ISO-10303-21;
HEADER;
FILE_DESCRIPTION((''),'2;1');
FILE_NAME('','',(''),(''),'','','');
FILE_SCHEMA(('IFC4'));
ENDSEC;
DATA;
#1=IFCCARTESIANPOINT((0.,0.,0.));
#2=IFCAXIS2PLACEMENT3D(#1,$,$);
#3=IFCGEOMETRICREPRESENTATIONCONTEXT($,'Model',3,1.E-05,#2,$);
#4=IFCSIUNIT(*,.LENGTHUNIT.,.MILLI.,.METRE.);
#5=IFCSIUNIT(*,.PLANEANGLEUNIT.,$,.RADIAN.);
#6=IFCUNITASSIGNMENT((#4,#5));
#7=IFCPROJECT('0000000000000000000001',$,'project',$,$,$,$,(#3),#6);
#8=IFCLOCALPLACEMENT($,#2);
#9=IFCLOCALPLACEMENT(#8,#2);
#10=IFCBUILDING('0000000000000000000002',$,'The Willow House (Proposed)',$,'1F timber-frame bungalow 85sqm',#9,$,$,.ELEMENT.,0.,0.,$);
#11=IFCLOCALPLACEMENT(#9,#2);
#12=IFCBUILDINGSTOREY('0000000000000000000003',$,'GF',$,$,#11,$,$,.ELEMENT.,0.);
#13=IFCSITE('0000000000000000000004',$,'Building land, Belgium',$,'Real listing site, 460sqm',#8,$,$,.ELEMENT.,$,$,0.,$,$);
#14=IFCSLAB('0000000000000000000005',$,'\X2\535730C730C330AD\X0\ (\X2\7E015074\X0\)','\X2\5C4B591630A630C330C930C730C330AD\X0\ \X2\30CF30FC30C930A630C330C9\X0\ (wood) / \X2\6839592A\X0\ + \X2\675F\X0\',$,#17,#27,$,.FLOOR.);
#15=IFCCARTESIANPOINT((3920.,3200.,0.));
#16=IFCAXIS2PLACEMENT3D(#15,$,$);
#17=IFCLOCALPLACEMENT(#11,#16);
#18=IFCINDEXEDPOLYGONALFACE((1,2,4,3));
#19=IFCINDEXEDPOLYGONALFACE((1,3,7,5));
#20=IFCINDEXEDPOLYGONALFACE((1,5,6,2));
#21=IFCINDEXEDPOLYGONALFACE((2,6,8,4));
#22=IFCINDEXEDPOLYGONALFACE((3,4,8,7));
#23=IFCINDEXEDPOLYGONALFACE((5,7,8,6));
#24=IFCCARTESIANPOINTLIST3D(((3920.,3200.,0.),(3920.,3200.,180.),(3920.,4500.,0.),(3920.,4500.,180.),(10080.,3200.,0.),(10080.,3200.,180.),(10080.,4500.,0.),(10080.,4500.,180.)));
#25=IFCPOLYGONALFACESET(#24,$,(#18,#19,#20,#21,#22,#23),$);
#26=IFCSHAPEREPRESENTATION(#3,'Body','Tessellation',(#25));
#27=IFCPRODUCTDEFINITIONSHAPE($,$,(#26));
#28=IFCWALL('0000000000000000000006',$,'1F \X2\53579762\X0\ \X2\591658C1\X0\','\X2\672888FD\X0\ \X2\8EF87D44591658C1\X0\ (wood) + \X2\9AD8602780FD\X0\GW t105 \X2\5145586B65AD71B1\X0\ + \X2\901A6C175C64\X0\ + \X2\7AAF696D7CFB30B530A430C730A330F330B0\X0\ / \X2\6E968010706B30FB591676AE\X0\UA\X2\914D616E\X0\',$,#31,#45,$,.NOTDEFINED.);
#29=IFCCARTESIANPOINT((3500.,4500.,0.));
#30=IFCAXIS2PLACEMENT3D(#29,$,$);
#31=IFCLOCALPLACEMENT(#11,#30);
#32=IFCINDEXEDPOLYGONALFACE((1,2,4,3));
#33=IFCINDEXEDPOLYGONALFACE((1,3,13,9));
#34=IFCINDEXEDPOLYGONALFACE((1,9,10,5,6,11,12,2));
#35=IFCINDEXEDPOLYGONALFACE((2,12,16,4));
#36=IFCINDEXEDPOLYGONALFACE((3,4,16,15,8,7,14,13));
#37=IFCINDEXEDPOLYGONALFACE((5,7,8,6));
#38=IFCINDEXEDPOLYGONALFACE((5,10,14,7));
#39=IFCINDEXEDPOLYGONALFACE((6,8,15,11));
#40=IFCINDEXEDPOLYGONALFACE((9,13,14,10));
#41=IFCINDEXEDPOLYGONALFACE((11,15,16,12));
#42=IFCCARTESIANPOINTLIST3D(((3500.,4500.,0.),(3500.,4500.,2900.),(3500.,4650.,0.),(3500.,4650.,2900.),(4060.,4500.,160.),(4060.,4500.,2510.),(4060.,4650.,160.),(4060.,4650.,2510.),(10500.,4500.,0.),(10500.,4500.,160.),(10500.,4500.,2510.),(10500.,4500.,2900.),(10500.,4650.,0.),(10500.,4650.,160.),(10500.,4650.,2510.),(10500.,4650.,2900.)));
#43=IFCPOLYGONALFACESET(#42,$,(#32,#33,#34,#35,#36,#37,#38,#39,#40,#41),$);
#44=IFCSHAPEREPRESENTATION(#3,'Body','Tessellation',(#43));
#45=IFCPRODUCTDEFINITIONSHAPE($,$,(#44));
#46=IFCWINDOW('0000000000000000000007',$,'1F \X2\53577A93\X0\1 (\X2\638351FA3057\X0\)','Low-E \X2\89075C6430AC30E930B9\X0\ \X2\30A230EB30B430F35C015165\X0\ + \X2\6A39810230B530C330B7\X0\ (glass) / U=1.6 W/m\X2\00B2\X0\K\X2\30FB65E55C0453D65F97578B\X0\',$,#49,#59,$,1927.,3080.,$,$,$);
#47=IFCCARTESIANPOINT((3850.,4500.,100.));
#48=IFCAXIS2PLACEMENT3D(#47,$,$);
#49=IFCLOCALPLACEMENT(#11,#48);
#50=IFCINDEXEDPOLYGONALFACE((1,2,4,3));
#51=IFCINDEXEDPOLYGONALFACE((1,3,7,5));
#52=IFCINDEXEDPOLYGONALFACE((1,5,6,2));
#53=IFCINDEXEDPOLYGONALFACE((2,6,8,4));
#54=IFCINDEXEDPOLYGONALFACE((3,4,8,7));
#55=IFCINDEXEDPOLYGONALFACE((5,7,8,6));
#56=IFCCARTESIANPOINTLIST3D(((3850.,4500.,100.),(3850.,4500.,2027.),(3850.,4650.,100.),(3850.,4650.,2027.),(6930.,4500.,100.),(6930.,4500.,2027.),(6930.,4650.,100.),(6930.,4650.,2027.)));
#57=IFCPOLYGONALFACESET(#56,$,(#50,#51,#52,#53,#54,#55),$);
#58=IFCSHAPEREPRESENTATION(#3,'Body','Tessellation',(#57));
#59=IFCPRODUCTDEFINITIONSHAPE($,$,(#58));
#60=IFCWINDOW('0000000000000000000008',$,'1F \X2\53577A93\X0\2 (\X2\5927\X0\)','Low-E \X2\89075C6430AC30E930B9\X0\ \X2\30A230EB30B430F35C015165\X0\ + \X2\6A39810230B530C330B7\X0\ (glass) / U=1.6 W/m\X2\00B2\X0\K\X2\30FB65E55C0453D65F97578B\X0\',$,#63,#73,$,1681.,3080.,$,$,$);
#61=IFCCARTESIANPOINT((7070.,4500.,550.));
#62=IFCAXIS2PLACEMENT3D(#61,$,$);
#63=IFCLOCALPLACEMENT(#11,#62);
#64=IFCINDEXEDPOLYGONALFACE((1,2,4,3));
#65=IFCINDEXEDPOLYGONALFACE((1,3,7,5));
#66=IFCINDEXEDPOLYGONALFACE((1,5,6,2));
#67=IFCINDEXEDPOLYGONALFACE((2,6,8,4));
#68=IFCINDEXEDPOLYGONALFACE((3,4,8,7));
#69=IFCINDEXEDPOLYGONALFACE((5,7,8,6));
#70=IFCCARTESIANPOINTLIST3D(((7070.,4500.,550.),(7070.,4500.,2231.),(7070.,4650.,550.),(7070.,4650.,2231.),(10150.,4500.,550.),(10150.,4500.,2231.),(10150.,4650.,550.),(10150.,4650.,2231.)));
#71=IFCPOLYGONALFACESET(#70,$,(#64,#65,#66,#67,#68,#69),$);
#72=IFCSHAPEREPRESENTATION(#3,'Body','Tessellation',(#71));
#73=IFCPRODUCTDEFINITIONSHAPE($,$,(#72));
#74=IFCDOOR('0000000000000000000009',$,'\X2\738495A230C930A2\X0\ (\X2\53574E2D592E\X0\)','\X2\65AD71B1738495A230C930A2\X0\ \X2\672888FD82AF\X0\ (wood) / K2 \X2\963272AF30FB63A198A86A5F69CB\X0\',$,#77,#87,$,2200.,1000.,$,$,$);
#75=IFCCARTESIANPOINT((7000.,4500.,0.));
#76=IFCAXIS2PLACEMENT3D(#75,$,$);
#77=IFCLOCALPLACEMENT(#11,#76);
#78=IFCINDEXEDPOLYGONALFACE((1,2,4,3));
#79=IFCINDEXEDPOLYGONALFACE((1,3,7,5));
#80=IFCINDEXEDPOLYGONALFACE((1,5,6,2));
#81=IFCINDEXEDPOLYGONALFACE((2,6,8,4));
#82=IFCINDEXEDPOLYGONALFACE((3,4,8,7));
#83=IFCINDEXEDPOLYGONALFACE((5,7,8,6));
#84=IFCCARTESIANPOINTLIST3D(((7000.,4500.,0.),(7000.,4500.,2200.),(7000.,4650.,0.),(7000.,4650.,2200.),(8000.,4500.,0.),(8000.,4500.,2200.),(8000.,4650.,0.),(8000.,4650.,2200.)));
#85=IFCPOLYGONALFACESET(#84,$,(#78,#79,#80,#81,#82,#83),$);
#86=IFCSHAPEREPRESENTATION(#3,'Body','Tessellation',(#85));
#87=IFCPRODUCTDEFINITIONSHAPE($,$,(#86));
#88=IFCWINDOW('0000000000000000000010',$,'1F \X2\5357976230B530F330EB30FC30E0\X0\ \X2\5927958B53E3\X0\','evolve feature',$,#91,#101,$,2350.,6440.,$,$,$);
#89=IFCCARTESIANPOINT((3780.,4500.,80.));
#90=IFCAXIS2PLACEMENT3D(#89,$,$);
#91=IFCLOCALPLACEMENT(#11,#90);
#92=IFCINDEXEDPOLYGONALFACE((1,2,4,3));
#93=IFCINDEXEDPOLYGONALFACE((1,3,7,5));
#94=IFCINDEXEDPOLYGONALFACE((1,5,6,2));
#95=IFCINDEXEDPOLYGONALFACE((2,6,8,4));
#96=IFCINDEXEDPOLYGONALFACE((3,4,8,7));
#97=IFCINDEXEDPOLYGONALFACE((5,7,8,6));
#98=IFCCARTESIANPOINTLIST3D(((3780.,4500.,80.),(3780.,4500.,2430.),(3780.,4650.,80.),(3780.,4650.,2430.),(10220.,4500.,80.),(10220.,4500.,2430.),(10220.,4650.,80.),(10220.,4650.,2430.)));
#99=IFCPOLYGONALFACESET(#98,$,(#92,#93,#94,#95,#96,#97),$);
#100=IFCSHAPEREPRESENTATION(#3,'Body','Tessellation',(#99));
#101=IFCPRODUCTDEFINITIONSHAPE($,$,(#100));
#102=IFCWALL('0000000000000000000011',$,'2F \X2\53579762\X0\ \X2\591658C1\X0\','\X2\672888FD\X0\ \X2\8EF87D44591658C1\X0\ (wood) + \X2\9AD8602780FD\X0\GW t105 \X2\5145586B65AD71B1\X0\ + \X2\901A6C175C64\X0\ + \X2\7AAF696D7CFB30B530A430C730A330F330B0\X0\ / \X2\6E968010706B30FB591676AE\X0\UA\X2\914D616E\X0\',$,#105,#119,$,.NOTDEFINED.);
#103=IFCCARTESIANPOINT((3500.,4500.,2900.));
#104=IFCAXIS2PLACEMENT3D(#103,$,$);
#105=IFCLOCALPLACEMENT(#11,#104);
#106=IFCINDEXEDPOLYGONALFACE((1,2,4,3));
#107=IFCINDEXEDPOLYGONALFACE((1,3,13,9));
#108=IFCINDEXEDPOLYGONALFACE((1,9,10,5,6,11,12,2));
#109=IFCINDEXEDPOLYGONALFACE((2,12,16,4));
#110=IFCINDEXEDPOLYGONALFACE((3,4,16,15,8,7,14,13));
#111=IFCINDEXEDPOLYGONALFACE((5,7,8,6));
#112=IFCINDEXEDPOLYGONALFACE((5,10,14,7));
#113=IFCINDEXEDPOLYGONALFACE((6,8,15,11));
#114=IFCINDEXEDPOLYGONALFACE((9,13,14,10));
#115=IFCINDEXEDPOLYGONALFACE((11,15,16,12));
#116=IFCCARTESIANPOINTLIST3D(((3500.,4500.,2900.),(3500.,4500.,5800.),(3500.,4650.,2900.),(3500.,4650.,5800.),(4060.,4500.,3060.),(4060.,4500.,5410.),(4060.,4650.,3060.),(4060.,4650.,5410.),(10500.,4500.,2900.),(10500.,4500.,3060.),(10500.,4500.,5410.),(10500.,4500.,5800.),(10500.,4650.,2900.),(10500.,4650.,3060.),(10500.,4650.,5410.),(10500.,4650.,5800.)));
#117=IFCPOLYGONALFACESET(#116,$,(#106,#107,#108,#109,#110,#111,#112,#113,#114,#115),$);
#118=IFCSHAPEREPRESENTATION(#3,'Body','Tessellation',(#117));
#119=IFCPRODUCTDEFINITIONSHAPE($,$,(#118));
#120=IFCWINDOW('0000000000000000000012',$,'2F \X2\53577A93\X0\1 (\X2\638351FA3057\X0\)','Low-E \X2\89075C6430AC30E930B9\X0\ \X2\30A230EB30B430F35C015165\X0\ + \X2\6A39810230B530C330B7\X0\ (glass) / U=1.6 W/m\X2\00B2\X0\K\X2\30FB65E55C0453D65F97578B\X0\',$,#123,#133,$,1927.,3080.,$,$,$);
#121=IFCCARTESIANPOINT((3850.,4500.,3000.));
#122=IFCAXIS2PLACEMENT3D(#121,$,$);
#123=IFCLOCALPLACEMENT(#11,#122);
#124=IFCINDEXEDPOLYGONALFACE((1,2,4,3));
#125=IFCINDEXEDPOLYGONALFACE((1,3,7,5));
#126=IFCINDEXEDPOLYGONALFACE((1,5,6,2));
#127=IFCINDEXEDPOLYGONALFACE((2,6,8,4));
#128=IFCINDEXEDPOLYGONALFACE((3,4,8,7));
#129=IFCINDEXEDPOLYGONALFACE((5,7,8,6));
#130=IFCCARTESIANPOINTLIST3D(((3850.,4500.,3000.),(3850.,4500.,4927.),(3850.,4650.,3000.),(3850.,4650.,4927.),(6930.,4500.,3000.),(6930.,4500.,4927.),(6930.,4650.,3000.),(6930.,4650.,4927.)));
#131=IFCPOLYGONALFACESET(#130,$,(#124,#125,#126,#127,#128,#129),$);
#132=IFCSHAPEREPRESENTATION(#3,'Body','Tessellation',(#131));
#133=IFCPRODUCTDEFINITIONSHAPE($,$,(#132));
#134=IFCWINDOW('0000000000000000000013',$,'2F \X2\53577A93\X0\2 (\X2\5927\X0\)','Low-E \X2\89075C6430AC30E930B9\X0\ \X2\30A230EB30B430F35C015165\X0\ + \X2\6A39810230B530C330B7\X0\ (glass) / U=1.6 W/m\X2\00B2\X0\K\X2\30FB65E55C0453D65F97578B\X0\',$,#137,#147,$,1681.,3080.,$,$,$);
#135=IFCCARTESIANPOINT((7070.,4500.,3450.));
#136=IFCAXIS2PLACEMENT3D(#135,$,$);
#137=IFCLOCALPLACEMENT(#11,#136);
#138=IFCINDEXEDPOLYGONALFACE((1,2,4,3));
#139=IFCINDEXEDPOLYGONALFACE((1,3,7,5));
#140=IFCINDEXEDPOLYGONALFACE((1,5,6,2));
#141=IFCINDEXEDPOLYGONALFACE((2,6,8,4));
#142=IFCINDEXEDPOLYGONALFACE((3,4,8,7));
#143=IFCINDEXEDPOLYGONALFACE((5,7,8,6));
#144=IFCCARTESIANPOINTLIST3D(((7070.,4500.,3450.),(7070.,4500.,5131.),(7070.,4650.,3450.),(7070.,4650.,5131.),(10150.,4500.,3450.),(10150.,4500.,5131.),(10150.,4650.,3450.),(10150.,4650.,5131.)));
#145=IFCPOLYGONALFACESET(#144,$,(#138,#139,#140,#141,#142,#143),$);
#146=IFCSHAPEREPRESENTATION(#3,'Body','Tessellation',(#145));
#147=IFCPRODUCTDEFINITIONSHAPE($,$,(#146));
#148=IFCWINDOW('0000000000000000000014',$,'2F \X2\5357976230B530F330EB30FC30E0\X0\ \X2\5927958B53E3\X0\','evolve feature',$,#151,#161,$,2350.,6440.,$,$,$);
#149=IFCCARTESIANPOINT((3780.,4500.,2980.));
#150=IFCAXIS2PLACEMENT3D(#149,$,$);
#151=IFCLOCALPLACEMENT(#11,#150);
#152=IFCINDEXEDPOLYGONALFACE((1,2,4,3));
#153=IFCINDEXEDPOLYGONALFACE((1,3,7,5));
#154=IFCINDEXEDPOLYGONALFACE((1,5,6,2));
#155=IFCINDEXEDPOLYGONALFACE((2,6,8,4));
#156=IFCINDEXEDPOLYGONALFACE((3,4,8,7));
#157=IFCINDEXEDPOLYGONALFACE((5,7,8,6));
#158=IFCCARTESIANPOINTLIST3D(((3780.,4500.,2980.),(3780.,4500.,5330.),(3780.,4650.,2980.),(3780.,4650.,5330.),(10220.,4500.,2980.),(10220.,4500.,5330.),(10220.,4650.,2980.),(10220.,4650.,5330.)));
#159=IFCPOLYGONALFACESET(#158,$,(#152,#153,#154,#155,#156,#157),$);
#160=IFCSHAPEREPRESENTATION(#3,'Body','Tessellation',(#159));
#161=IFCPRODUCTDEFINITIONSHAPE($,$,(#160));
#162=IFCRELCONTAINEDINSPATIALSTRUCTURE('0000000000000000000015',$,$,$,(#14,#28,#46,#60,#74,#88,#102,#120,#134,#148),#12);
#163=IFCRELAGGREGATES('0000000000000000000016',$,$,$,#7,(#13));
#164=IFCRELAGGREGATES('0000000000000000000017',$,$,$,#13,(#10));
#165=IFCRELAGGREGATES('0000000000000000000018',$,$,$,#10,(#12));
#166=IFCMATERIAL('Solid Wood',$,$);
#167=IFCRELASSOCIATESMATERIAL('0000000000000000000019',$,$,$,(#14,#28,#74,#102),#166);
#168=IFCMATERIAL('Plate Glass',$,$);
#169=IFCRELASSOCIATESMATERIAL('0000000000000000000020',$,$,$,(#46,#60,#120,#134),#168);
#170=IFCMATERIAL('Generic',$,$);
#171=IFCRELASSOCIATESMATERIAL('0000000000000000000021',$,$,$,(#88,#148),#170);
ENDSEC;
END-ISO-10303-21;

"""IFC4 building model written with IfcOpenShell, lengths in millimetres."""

from ifc_helpers import new_model, si_unit, frame, frame_2d, origin, place, context, project, spatial, rectangle, extrude, material, element, fill, save


model = new_model("IFC4")

# Units and contexts
model_context = context("Model", 3, precision=1e-05, world=origin())
ifc_project = project(units=[si_unit("LENGTHUNIT", "METRE", prefix="MILLI"), si_unit("PLANEANGLEUNIT", "RADIAN")], contexts=[model_context])

# Site, building, storey
site_placement = place(None, origin())
site = spatial("IfcSite", under=ifc_project, at=site_placement, Name="Building land, Belgium", ObjectType="Real listing site, 460sqm", CompositionType="ELEMENT", RefElevation=0.0)
building_placement = place(site_placement, origin())
building = spatial("IfcBuilding", under=site, at=building_placement, Name="The Willow House (Proposed)", ObjectType="1F timber-frame bungalow 85sqm", CompositionType="ELEMENT", ElevationOfRefHeight=0.0, ElevationOfTerrain=0.0)
storey_placement = place(building_placement, origin())
storey = spatial("IfcBuildingStorey", under=building, at=storey_placement, Name="GF", CompositionType="ELEMENT", Elevation=0.0)

# Slab
ifc_material_1 = material(Name="Solid Wood")
slab_1_placement = place(storey_placement, frame((3920.0, 3200.0, 0.0)))
element("IfcSlab", 1, at=slab_1_placement, inside=storey, material=ifc_material_1, Name="南デッキ (縁側)", Description="屋外ウッドデッキ ハードウッド (wood) / 根太 + 束", PredefinedType="FLOOR", context=model_context, shape_type="SweptSolid", body=[
    extrude(rectangle(XDim=6160.0, YDim=1300.0, at=frame_2d((3080.0, 650.0))), frame((3920.0, 3200.0, 0.0)), (0.0, 0.0, 1.0), 180.0),
])
ifc_material_2 = material(Name="Generic")

# Wall, openings, windows, door
wall_1_placement = place(storey_placement, frame((3500.0, 4500.0, 0.0)))
wall_1 = element("IfcWall", 2, at=wall_1_placement, inside=storey, material=ifc_material_1, Name="1F 南面 外壁", Description="木製 軸組外壁 (wood) + 高性能GW t105 充填断熱 + 通気層 + 窯業系サイディング / 準耐火・外皮UA配慮", PredefinedType="NOTDEFINED", context=model_context, shape_type="SweptSolid", body=[
    extrude(rectangle(XDim=7000.0, YDim=150.0, at=frame_2d((3500.0, 75.0))), frame((3500.0, 4500.0, 0.0)), (0.0, 0.0, 1.0), 2900.0),
])
opening_1_placement = place(storey_placement, frame((3850.0, 4500.0, 100.0)))
opening_1 = element("IfcOpeningElement", 3, at=opening_1_placement, cuts=wall_1, PredefinedType="NOTDEFINED", context=model_context, shape_type="SweptSolid", body=[
    extrude(rectangle(XDim=3080.0, YDim=150.0, at=frame_2d((1540.0, 75.0))), frame((3850.0, 4500.0, 100.0)), (0.0, 0.0, 1.0), 1927.0),
])
opening_2_placement = place(storey_placement, frame((7070.0, 4500.0, 550.0)))
opening_2 = element("IfcOpeningElement", 4, at=opening_2_placement, cuts=wall_1, PredefinedType="NOTDEFINED", context=model_context, shape_type="SweptSolid", body=[
    extrude(rectangle(XDim=3080.0, YDim=150.0, at=frame_2d((1540.0, 75.0))), frame((7070.0, 4500.0, 550.0)), (0.0, 0.0, 1.0), 1681.0),
])
opening_3_placement = place(storey_placement, frame((7000.0, 4500.0, 0.0)))
opening_3 = element("IfcOpeningElement", 5, at=opening_3_placement, cuts=wall_1, PredefinedType="NOTDEFINED", context=model_context, shape_type="SweptSolid", body=[
    extrude(rectangle(XDim=1000.0, YDim=150.0, at=frame_2d((500.0, 75.0))), frame((7000.0, 4500.0, 0.0)), (0.0, 0.0, 1.0), 2200.0),
])
opening_4_placement = place(storey_placement, frame((3780.0, 4500.0, 80.0)))
opening_4 = element("IfcOpeningElement", 6, at=opening_4_placement, cuts=wall_1, PredefinedType="NOTDEFINED", context=model_context, shape_type="SweptSolid", body=[
    extrude(rectangle(XDim=6440.0, YDim=150.0, at=frame_2d((3220.0, 75.0))), frame((3780.0, 4500.0, 80.0)), (0.0, 0.0, 1.0), 2350.0),
])
ifc_material_3 = material(Name="Plate Glass")
window_1_placement = place(storey_placement, frame((3850.0, 4500.0, 100.0)))
window_1 = element("IfcWindow", 7, at=window_1_placement, inside=storey, material=ifc_material_3, Name="1F 南窓1 (掃出し)", Description="Low-E 複層ガラス アルゴン封入 + 樹脂サッシ (glass) / U=1.6 W/m²K・日射取得型", OverallHeight=1927.0, OverallWidth=3080.0, context=model_context, shape_type="SweptSolid", body=[
    extrude(rectangle(XDim=3080.0, YDim=150.0, at=frame_2d((1540.0, 75.0))), frame((3850.0, 4500.0, 100.0)), (0.0, 0.0, 1.0), 1927.0),
])
fill(opening_1, window_1)
window_2_placement = place(storey_placement, frame((7070.0, 4500.0, 550.0)))
window_2 = element("IfcWindow", 8, at=window_2_placement, inside=storey, material=ifc_material_3, Name="1F 南窓2 (大)", Description="Low-E 複層ガラス アルゴン封入 + 樹脂サッシ (glass) / U=1.6 W/m²K・日射取得型", OverallHeight=1681.0, OverallWidth=3080.0, context=model_context, shape_type="SweptSolid", body=[
    extrude(rectangle(XDim=3080.0, YDim=150.0, at=frame_2d((1540.0, 75.0))), frame((7070.0, 4500.0, 550.0)), (0.0, 0.0, 1.0), 1681.0),
])
fill(opening_2, window_2)
door_placement = place(storey_placement, frame((7000.0, 4500.0, 0.0)))
door = element("IfcDoor", 9, at=door_placement, inside=storey, material=ifc_material_1, Name="玄関ドア (南中央)", Description="断熱玄関ドア 木製芯 (wood) / K2 防犯・採風機構", OverallHeight=2200.0, OverallWidth=1000.0, context=model_context, shape_type="SweptSolid", body=[
    extrude(rectangle(XDim=1000.0, YDim=150.0, at=frame_2d((500.0, 75.0))), frame((7000.0, 4500.0, 0.0)), (0.0, 0.0, 1.0), 2200.0),
])
fill(opening_3, door)
window_3_placement = place(storey_placement, frame((3780.0, 4500.0, 80.0)))
window_3 = element("IfcWindow", 10, at=window_3_placement, inside=storey, material=ifc_material_2, Name="1F 南面サンルーム 大開口", Description="evolve feature", OverallHeight=2350.0, OverallWidth=6440.0, context=model_context, shape_type="SweptSolid", body=[
    extrude(rectangle(XDim=6440.0, YDim=150.0, at=frame_2d((3220.0, 75.0))), frame((3780.0, 4500.0, 80.0)), (0.0, 0.0, 1.0), 2350.0),
])
fill(opening_4, window_3)

# Wall, openings, windows
wall_2_placement = place(storey_placement, frame((3500.0, 4500.0, 2900.0)))
wall_2 = element("IfcWall", 11, at=wall_2_placement, inside=storey, material=ifc_material_1, Name="2F 南面 外壁", Description="木製 軸組外壁 (wood) + 高性能GW t105 充填断熱 + 通気層 + 窯業系サイディング / 準耐火・外皮UA配慮", PredefinedType="NOTDEFINED", context=model_context, shape_type="SweptSolid", body=[
    extrude(rectangle(XDim=7000.0, YDim=150.0, at=frame_2d((3500.0, 75.0))), frame((3500.0, 4500.0, 2900.0)), (0.0, 0.0, 1.0), 2900.0),
])
opening_5_placement = place(storey_placement, frame((3850.0, 4500.0, 3000.0)))
opening_5 = element("IfcOpeningElement", 12, at=opening_5_placement, cuts=wall_2, PredefinedType="NOTDEFINED", context=model_context, shape_type="SweptSolid", body=[
    extrude(rectangle(XDim=3080.0, YDim=150.0, at=frame_2d((1540.0, 75.0))), frame((3850.0, 4500.0, 3000.0)), (0.0, 0.0, 1.0), 1927.0),
])
opening_6_placement = place(storey_placement, frame((7070.0, 4500.0, 3450.0)))
opening_6 = element("IfcOpeningElement", 13, at=opening_6_placement, cuts=wall_2, PredefinedType="NOTDEFINED", context=model_context, shape_type="SweptSolid", body=[
    extrude(rectangle(XDim=3080.0, YDim=150.0, at=frame_2d((1540.0, 75.0))), frame((7070.0, 4500.0, 3450.0)), (0.0, 0.0, 1.0), 1681.0),
])
opening_7_placement = place(storey_placement, frame((3780.0, 4500.0, 2980.0)))
opening_7 = element("IfcOpeningElement", 14, at=opening_7_placement, cuts=wall_2, PredefinedType="NOTDEFINED", context=model_context, shape_type="SweptSolid", body=[
    extrude(rectangle(XDim=6440.0, YDim=150.0, at=frame_2d((3220.0, 75.0))), frame((3780.0, 4500.0, 2980.0)), (0.0, 0.0, 1.0), 2350.0),
])
window_4_placement = place(storey_placement, frame((3850.0, 4500.0, 3000.0)))
window_4 = element("IfcWindow", 15, at=window_4_placement, inside=storey, material=ifc_material_3, Name="2F 南窓1 (掃出し)", Description="Low-E 複層ガラス アルゴン封入 + 樹脂サッシ (glass) / U=1.6 W/m²K・日射取得型", OverallHeight=1927.0, OverallWidth=3080.0, context=model_context, shape_type="SweptSolid", body=[
    extrude(rectangle(XDim=3080.0, YDim=150.0, at=frame_2d((1540.0, 75.0))), frame((3850.0, 4500.0, 3000.0)), (0.0, 0.0, 1.0), 1927.0),
])
fill(opening_5, window_4)
window_5_placement = place(storey_placement, frame((7070.0, 4500.0, 3450.0)))
window_5 = element("IfcWindow", 16, at=window_5_placement, inside=storey, material=ifc_material_3, Name="2F 南窓2 (大)", Description="Low-E 複層ガラス アルゴン封入 + 樹脂サッシ (glass) / U=1.6 W/m²K・日射取得型", OverallHeight=1681.0, OverallWidth=3080.0, context=model_context, shape_type="SweptSolid", body=[
    extrude(rectangle(XDim=3080.0, YDim=150.0, at=frame_2d((1540.0, 75.0))), frame((7070.0, 4500.0, 3450.0)), (0.0, 0.0, 1.0), 1681.0),
])
fill(opening_6, window_5)
window_6_placement = place(storey_placement, frame((3780.0, 4500.0, 2980.0)))
window_6 = element("IfcWindow", 17, at=window_6_placement, inside=storey, material=ifc_material_2, Name="2F 南面サンルーム 大開口", Description="evolve feature", OverallHeight=2350.0, OverallWidth=6440.0, context=model_context, shape_type="SweptSolid", body=[
    extrude(rectangle(XDim=6440.0, YDim=150.0, at=frame_2d((3220.0, 75.0))), frame((3780.0, 4500.0, 2980.0)), (0.0, 0.0, 1.0), 2350.0),
])
fill(opening_7, window_6)

save(model, "model.ifc")
